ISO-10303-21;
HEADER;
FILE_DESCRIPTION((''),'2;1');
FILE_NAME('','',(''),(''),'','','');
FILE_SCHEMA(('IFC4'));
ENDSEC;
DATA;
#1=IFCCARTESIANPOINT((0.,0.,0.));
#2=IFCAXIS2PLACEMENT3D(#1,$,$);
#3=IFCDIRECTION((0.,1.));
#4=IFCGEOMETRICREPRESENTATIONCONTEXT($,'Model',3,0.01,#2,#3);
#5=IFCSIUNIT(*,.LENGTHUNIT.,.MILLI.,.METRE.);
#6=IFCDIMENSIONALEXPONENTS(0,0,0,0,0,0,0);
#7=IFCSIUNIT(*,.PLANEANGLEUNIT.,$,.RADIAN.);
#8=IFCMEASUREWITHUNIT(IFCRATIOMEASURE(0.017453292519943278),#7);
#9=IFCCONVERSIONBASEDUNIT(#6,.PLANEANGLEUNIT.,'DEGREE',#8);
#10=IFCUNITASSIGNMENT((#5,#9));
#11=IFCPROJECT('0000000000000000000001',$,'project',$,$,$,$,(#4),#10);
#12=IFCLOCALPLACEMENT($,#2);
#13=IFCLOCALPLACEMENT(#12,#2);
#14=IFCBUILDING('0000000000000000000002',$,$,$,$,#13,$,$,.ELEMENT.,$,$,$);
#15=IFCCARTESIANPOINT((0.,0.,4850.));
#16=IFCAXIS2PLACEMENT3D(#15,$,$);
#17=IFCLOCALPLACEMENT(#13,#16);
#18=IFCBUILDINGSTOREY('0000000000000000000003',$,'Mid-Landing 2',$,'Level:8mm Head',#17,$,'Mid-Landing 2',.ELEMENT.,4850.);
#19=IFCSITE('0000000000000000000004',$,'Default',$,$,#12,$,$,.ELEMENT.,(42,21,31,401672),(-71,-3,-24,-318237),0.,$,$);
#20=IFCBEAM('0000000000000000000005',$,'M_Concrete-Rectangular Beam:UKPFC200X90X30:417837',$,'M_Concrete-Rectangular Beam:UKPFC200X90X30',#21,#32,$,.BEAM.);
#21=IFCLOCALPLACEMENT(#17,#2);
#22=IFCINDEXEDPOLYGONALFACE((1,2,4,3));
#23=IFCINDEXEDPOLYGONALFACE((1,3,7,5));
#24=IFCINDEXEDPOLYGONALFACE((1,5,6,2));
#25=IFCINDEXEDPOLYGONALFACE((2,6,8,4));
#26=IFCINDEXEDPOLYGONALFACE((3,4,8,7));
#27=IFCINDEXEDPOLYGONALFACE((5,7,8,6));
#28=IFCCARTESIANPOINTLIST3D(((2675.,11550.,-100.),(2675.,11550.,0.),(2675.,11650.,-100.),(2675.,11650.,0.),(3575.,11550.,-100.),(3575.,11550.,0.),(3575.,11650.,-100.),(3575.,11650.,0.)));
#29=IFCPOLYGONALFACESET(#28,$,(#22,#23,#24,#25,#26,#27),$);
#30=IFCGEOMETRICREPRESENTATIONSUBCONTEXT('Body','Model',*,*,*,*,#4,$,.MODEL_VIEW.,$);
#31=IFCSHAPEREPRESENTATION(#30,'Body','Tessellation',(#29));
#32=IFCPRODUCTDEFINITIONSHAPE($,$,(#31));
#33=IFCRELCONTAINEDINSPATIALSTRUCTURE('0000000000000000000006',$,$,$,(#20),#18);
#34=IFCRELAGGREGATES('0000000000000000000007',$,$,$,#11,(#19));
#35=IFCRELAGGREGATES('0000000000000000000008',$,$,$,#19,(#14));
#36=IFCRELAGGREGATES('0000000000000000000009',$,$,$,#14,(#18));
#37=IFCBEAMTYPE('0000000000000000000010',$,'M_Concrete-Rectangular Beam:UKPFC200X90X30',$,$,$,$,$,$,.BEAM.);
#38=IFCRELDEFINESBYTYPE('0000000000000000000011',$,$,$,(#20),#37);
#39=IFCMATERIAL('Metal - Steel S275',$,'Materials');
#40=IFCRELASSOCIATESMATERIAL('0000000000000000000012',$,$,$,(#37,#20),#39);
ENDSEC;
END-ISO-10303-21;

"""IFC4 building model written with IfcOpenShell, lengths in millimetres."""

from ifc_helpers import new_model, entity, si_unit, converted_unit, direction, frame, origin, place, context, subcontext, project, spatial, indexed_curve, outline, extrude, source, transform, mapped, material, type_object, type_shapes, element, save


model = new_model("IFC4")

# Units and contexts
model_context = context("Model", 3, precision=0.01, world=origin(), true_north=direction((0.0, 1.0)))
body_context = subcontext(model_context, "Body", "Model", "MODEL_VIEW")
ifc_project = project(units=[si_unit("LENGTHUNIT", "METRE", prefix="MILLI"), converted_unit("PLANEANGLEUNIT", "DEGREE", entity("IfcRatioMeasure", 0.017453292519943278), si_unit("PLANEANGLEUNIT", "RADIAN"), dimensions=[0, 0, 0, 0, 0, 0, 0])], contexts=[model_context])

# Site, building, storey
site_placement = place(None, origin())
site = spatial("IfcSite", under=ifc_project, at=site_placement, Name="Default", CompositionType="ELEMENT", RefLatitude=(42, 21, 31, 401672), RefLongitude=(-71, -3, -24, -318237), RefElevation=0.0)
building_placement = place(site_placement, origin())
building = spatial("IfcBuilding", under=site, at=building_placement, CompositionType="ELEMENT")
storey_placement = place(building_placement, frame((0.0, 0.0, 4850.0)))
storey = spatial("IfcBuildingStorey", under=building, at=storey_placement, Name="Mid-Landing 2", ObjectType="Level:8mm Head", LongName="Mid-Landing 2", CompositionType="ELEMENT", Elevation=4850.0)

# Beam
ifc_material = material(Name="Metal - Steel S275", Category="Materials")
beam_type_1 = type_object("IfcBeamType", Name="M_Concrete-Rectangular Beam:UKPFC200X90X30", PredefinedType="BEAM", material=ifc_material)
shared_shape_1 = source(origin(), body_context, "Body", "SweptSolid", [
    extrude(outline(indexed_curve([(-50.0, -50.0), (50.0, -50.0), (50.0, 50.0), (-50.0, 50.0), (-50.0, -50.0)], self_intersect=False)), frame((2675.0, 11600.0, 4800.0), z_axis=(1.0, 0.0, 0.0), x_axis=(0.0, 0.0, -1.0)), (0.0, 0.0, 1.0), 900.0),
])
type_shapes(beam_type_1, [shared_shape_1])
beam_1_placement = place(storey_placement, frame((0.0, 0.0, -4850.0)))
element("IfcBeam", 1, at=beam_1_placement, inside=storey, type_object=beam_type_1, material=ifc_material, Name="M_Concrete-Rectangular Beam:UKPFC200X90X30:417837", ObjectType="M_Concrete-Rectangular Beam:UKPFC200X90X30", PredefinedType="BEAM", context=body_context, shape_type="MappedRepresentation", body=[
    mapped(shared_shape_1, transform((0.0, 0.0, 0.0), scale=1.0)),
])

save(model, "model.ifc")
